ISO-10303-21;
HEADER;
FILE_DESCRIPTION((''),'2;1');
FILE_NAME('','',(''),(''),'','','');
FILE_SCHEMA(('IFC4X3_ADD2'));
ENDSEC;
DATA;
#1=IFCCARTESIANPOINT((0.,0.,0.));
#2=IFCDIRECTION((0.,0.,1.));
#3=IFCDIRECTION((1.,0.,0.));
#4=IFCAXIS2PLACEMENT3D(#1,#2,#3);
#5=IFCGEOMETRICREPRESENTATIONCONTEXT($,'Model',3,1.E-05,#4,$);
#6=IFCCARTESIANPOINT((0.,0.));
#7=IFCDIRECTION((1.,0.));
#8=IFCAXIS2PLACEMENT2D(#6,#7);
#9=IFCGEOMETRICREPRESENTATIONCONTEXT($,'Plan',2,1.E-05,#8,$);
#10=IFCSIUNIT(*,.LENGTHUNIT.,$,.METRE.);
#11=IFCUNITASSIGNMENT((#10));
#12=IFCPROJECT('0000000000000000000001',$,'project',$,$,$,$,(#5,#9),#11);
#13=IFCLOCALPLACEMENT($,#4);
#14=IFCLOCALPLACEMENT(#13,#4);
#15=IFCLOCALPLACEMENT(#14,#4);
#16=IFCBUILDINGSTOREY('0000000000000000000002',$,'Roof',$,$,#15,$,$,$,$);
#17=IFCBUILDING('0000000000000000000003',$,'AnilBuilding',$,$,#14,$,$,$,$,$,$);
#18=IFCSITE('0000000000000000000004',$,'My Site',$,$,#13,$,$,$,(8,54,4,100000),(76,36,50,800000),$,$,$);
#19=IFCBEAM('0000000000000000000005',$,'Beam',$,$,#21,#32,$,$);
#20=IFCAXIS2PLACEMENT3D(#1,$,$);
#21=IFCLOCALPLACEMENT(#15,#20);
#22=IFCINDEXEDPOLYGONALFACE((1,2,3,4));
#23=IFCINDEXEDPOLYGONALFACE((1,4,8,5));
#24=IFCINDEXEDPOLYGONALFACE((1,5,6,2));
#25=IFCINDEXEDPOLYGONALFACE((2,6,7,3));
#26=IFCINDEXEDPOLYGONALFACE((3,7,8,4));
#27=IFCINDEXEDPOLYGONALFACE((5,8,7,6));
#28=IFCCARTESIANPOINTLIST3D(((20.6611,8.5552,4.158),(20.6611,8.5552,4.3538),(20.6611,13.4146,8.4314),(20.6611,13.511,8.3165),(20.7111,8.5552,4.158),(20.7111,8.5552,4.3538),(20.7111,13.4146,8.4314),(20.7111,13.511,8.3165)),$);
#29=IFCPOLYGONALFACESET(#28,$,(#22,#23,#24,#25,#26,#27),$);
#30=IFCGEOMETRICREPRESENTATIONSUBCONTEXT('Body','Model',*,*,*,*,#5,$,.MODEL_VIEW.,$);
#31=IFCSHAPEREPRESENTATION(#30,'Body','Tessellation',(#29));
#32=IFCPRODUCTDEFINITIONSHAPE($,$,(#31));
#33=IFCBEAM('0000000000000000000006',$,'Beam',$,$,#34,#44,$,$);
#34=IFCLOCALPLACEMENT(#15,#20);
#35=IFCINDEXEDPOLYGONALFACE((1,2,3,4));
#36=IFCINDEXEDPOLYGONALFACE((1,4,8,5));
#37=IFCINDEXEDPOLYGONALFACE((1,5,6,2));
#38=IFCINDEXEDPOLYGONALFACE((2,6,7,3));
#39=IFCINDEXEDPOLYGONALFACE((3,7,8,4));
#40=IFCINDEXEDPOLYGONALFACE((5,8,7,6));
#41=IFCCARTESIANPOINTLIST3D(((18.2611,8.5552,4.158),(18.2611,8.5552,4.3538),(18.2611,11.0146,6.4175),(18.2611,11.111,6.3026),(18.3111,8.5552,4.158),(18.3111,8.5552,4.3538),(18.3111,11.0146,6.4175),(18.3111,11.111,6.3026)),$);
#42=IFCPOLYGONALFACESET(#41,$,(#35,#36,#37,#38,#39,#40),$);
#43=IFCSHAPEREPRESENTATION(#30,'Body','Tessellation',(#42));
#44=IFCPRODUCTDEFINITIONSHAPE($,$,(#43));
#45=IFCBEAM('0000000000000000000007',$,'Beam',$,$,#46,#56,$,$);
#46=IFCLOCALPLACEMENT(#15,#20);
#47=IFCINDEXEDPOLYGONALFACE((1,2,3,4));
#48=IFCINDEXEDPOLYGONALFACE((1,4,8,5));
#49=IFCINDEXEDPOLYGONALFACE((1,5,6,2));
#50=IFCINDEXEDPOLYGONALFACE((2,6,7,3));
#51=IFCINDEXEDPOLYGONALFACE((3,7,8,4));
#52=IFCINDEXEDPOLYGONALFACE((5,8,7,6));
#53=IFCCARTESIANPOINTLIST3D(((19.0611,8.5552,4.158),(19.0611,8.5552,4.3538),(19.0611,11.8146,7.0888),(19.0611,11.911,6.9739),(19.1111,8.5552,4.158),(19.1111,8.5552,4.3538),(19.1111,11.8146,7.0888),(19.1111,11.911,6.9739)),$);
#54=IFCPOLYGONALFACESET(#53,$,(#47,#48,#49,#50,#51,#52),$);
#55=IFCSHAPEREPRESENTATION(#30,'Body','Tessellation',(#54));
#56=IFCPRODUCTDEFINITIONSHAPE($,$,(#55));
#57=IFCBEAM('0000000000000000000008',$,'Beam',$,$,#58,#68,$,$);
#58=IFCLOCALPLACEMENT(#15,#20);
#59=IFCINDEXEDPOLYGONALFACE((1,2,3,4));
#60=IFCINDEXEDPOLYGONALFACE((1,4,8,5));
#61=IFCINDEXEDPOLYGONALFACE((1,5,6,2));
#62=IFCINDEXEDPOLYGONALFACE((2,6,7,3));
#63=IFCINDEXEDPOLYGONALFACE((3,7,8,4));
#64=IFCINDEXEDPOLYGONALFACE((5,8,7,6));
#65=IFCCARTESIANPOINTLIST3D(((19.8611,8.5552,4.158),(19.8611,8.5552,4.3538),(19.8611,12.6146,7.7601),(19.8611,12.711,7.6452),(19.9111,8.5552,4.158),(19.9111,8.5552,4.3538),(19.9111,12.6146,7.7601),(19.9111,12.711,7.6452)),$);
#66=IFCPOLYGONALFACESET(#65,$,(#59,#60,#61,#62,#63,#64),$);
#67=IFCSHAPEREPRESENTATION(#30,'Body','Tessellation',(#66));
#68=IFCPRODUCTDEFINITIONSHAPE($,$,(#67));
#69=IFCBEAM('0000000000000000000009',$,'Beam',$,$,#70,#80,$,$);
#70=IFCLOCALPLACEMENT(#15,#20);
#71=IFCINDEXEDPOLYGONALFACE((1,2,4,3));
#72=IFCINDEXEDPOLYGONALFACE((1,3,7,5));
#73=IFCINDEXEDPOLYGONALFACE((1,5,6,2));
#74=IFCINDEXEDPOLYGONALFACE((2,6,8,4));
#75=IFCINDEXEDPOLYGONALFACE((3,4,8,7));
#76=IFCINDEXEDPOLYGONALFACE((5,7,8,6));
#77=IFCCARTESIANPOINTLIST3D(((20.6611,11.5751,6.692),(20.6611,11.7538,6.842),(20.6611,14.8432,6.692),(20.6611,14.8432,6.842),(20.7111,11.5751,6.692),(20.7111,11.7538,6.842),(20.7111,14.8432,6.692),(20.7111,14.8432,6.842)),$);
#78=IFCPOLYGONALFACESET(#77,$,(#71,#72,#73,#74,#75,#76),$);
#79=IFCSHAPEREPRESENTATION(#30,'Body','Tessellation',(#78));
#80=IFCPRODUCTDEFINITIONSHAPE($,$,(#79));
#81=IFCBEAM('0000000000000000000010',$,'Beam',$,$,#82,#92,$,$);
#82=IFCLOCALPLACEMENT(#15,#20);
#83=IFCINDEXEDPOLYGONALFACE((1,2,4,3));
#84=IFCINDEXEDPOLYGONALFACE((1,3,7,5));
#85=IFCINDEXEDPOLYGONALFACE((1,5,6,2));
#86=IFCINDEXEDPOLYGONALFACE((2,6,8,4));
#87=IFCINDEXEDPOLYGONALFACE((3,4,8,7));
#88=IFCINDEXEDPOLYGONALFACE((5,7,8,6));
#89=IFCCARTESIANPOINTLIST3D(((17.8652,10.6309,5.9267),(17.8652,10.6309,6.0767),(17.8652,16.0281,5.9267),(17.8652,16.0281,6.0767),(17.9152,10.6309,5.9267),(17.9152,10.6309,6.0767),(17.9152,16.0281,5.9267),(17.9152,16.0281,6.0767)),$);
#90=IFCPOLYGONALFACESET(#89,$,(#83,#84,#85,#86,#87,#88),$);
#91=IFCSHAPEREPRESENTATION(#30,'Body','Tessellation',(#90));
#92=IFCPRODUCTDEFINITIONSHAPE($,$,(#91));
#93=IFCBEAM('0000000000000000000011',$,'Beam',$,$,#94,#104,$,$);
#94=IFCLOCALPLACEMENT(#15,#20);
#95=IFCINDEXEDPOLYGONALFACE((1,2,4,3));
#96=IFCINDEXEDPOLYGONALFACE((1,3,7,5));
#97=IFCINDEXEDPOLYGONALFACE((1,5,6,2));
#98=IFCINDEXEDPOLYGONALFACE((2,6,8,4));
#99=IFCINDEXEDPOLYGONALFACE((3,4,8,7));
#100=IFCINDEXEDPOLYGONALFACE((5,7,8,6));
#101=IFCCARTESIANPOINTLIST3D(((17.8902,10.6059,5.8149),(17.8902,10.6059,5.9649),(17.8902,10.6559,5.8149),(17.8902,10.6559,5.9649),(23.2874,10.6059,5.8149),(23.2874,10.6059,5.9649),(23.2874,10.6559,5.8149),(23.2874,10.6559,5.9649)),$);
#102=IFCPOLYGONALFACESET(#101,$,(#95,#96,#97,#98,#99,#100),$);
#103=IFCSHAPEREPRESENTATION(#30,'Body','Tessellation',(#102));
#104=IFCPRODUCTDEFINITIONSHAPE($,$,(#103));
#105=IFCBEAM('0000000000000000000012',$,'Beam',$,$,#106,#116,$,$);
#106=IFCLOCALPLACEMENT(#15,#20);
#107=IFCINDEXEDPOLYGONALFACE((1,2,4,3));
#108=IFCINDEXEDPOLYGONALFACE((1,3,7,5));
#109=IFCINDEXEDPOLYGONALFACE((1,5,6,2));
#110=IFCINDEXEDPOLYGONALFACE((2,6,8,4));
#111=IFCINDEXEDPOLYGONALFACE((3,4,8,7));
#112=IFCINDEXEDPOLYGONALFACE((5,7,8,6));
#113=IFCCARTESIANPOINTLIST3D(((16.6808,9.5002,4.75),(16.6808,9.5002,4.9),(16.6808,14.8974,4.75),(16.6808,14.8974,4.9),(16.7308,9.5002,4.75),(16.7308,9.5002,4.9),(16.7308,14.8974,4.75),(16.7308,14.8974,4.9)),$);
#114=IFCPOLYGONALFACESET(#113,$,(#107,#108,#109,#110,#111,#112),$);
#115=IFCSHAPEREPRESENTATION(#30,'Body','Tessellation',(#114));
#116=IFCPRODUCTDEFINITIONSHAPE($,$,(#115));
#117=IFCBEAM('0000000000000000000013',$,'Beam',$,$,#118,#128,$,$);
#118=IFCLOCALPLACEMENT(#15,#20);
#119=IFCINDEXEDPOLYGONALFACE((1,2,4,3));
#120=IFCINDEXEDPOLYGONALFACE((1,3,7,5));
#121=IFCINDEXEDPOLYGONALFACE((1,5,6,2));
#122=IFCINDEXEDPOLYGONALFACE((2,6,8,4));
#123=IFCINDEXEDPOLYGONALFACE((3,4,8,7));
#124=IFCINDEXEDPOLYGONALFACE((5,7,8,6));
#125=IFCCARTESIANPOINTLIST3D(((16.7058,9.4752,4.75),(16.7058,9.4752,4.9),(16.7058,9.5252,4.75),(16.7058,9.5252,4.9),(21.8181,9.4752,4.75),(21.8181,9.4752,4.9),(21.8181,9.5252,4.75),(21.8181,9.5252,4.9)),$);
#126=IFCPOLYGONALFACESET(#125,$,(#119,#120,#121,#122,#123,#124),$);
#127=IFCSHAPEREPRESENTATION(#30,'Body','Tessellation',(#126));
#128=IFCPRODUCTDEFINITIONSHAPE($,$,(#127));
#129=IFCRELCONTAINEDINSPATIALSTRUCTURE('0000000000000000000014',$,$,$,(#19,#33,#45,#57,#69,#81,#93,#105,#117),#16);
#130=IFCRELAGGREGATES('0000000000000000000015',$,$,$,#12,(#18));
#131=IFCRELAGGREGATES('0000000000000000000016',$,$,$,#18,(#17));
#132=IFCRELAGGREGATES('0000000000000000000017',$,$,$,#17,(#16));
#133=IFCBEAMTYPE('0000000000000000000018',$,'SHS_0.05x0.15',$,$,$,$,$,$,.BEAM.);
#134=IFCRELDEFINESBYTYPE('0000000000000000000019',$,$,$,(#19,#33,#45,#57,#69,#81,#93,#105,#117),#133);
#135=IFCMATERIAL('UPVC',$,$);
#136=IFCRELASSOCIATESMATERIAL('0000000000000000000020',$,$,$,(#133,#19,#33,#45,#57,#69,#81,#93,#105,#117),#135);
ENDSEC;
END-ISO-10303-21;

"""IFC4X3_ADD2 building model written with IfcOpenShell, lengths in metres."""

from ifc_helpers import new_model, si_unit, frame, origin_with_axes, origin_2d_with_axis, place, context, subcontext, project, spatial, indexed_curve, outline, extrude, clip, halfspace, material, material_profile, profile_set, profile_usage, type_object, element, save


model = new_model("IFC4X3_ADD2")

# Units and contexts
model_context = context("Model", 3, precision=1e-05, world=origin_with_axes())
plan_context = context("Plan", 2, precision=1e-05, world=origin_2d_with_axis())
body_context_1 = subcontext(model_context, "Body", "Model", "MODEL_VIEW")
ifc_project = project(units=[si_unit("LENGTHUNIT", "METRE")], contexts=[model_context, plan_context])

# Site, building, storey
site_placement = place(None, origin_with_axes())
site = spatial("IfcSite", under=ifc_project, at=site_placement, Name="My Site", RefLatitude=(8, 54, 4, 100000), RefLongitude=(76, 36, 50, 800000))
building_placement = place(site_placement, origin_with_axes())
building = spatial("IfcBuilding", under=site, at=building_placement, Name="AnilBuilding")
storey_placement = place(building_placement, origin_with_axes())
storey = spatial("IfcBuildingStorey", under=building, at=storey_placement, Name="Roof")

# Shared definitions
ifc_material_1 = material(Name="UPVC")

# Beams
ifc_material_profile_1 = material_profile(ifc_material_1, outline(indexed_curve([(-0.025, 0.075), (0.025, 0.075), (0.025, -0.075), (-0.025, -0.075), (-0.025, 0.075)])))
ifc_profile_set_1 = profile_set([ifc_material_profile_1])
beam_type = type_object("IfcBeamType", Name="SHS_0.05x0.15", PredefinedType="BEAM", material=ifc_profile_set_1)
ifc_profile_usage_1 = profile_usage(ifc_profile_set_1, cardinal=5)
beam_1_placement = place(storey_placement, frame((20.6861, 8.4403, 4.1595), z_axis=(0.000001, 0.766044, 0.642788), x_axis=(-1.0, 0.000001, 0.0)))
element("IfcBeam", 1, at=beam_1_placement, inside=storey, type_object=beam_type, material=ifc_profile_usage_1, Name="Beam", context=body_context_1, shape_type="Clipping", body=[
    clip(extrude(outline(indexed_curve([(-0.025, 0.075), (0.025, 0.075), (0.025, -0.075), (-0.025, -0.075), (-0.025, 0.075)])), origin_with_axes(), (0.0, 0.0, 1.0), 6.5564), halfspace(frame((4.9745, -0.0793, 0.0835), z_axis=(0.0, 0.642787, -0.766045), x_axis=(1.0, -0.000001, 0.0)), False)),
])
ifc_profile_usage_2 = profile_usage(ifc_profile_set_1, cardinal=5)
beam_2_placement = place(storey_placement, frame((18.2861, 8.4403, 4.1595), z_axis=(0.000001, 0.766044, 0.642788), x_axis=(-1.0, 0.000001, 0.0)))
element("IfcBeam", 2, at=beam_2_placement, inside=storey, type_object=beam_type, material=ifc_profile_usage_2, Name="Beam", context=body_context_1, shape_type="Clipping", body=[
    clip(extrude(outline(indexed_curve([(-0.025, 0.075), (0.025, 0.075), (0.025, -0.075), (-0.025, -0.075), (-0.025, 0.075)])), origin_with_axes(), (0.0, 0.0, 1.0), 3.4235), halfspace(frame((2.5745, -0.0793, 0.0835), z_axis=(0.0, 0.642787, -0.766045), x_axis=(1.0, -0.000001, 0.0)), False)),
])
ifc_profile_usage_3 = profile_usage(ifc_profile_set_1, cardinal=5)
beam_3_placement = place(storey_placement, frame((19.0861, 8.4403, 4.1595), z_axis=(0.000001, 0.766044, 0.642788), x_axis=(-1.0, 0.000001, 0.0)))
element("IfcBeam", 3, at=beam_3_placement, inside=storey, type_object=beam_type, material=ifc_profile_usage_3, Name="Beam", context=body_context_1, shape_type="Clipping", body=[
    clip(extrude(outline(indexed_curve([(-0.025, 0.075), (0.025, 0.075), (0.025, -0.075), (-0.025, -0.075), (-0.025, 0.075)])), origin_with_axes(), (0.0, 0.0, 1.0), 4.4678), halfspace(frame((3.3745, -0.0793, 0.0835), z_axis=(0.0, 0.642787, -0.766045), x_axis=(1.0, -0.000001, 0.0)), False)),
])
ifc_profile_usage_4 = profile_usage(ifc_profile_set_1, cardinal=5)
beam_4_placement = place(storey_placement, frame((19.8861, 8.4403, 4.1595), z_axis=(0.000001, 0.766044, 0.642788), x_axis=(-1.0, 0.000001, 0.0)))
element("IfcBeam", 4, at=beam_4_placement, inside=storey, type_object=beam_type, material=ifc_profile_usage_4, Name="Beam", context=body_context_1, shape_type="Clipping", body=[
    clip(extrude(outline(indexed_curve([(-0.025, 0.075), (0.025, 0.075), (0.025, -0.075), (-0.025, -0.075), (-0.025, 0.075)])), origin_with_axes(), (0.0, 0.0, 1.0), 5.5121), halfspace(frame((4.1745, -0.0793, 0.0835), z_axis=(0.0, 0.642787, -0.766045), x_axis=(1.0, -0.000001, 0.0)), False)),
])
ifc_profile_usage_5 = profile_usage(ifc_profile_set_1, cardinal=5)
beam_5_placement = place(storey_placement, frame((20.6861, 11.5144, 6.767), z_axis=(0.000001, 1.0, 0.0), x_axis=(-1.0, 0.000001, 0.0)))
element("IfcBeam", 5, at=beam_5_placement, inside=storey, type_object=beam_type, material=ifc_profile_usage_5, Name="Beam", context=body_context_1, shape_type="Clipping", body=[
    clip(extrude(outline(indexed_curve([(-0.025, 0.075), (0.025, 0.075), (0.025, -0.075), (-0.025, -0.075), (-0.025, 0.075)])), origin_with_axes(), (0.0, 0.0, 1.0), 3.3288), halfspace(frame((0.0, -2.3202, -2.6151), z_axis=(0.0, 0.766044, -0.642788), x_axis=(1.0, 0.0, 0.0)), False)),
])
ifc_profile_usage_6 = profile_usage(ifc_profile_set_1, cardinal=5)
beam_6_placement = place(storey_placement, frame((17.8902, 10.6309, 6.0017), z_axis=(0.000001, 1.0, 0.0), x_axis=(-1.0, 0.000001, 0.0)))
element("IfcBeam", 6, at=beam_6_placement, inside=storey, type_object=beam_type, material=ifc_profile_usage_6, Name="Beam", context=body_context_1, shape_type="SweptSolid", body=[
    extrude(outline(indexed_curve([(-0.025, 0.075), (0.025, 0.075), (0.025, -0.075), (-0.025, -0.075), (-0.025, 0.075)])), origin_with_axes(), (0.0, 0.0, 1.0), 5.3972),
])
ifc_profile_usage_7 = profile_usage(ifc_profile_set_1, cardinal=5)
beam_7_placement = place(storey_placement, frame((17.8902, 10.6309, 5.8899), z_axis=(1.0, -0.000001, 0.0), x_axis=(0.000001, 1.0, 0.0)))
element("IfcBeam", 7, at=beam_7_placement, inside=storey, type_object=beam_type, material=ifc_profile_usage_7, Name="Beam", context=body_context_1, shape_type="SweptSolid", body=[
    extrude(outline(indexed_curve([(-0.025, 0.075), (0.025, 0.075), (0.025, -0.075), (-0.025, -0.075), (-0.025, 0.075)])), origin_with_axes(), (0.0, 0.0, 1.0), 5.3972),
])
ifc_profile_usage_8 = profile_usage(ifc_profile_set_1, cardinal=5)
beam_8_placement = place(storey_placement, frame((16.7058, 9.5002, 4.825), z_axis=(0.000001, 1.0, 0.0), x_axis=(-1.0, 0.000001, 0.0)))
element("IfcBeam", 8, at=beam_8_placement, inside=storey, type_object=beam_type, material=ifc_profile_usage_8, Name="Beam", context=body_context_1, shape_type="SweptSolid", body=[
    extrude(outline(indexed_curve([(-0.025, 0.075), (0.025, 0.075), (0.025, -0.075), (-0.025, -0.075), (-0.025, 0.075)])), origin_with_axes(), (0.0, 0.0, 1.0), 5.3972),
])
ifc_profile_usage_9 = profile_usage(ifc_profile_set_1, cardinal=5)
beam_9_placement = place(storey_placement, frame((16.7058, 9.5002, 4.825), z_axis=(1.0, -0.000001, 0.0), x_axis=(0.000001, 1.0, 0.0)))
element("IfcBeam", 9, at=beam_9_placement, inside=storey, type_object=beam_type, material=ifc_profile_usage_9, Name="Beam", context=body_context_1, shape_type="SweptSolid", body=[
    extrude(outline(indexed_curve([(-0.025, 0.075), (0.025, 0.075), (0.025, -0.075), (-0.025, -0.075), (-0.025, 0.075)])), origin_with_axes(), (0.0, 0.0, 1.0), 5.1123),
])

save(model, "model.ifc")
